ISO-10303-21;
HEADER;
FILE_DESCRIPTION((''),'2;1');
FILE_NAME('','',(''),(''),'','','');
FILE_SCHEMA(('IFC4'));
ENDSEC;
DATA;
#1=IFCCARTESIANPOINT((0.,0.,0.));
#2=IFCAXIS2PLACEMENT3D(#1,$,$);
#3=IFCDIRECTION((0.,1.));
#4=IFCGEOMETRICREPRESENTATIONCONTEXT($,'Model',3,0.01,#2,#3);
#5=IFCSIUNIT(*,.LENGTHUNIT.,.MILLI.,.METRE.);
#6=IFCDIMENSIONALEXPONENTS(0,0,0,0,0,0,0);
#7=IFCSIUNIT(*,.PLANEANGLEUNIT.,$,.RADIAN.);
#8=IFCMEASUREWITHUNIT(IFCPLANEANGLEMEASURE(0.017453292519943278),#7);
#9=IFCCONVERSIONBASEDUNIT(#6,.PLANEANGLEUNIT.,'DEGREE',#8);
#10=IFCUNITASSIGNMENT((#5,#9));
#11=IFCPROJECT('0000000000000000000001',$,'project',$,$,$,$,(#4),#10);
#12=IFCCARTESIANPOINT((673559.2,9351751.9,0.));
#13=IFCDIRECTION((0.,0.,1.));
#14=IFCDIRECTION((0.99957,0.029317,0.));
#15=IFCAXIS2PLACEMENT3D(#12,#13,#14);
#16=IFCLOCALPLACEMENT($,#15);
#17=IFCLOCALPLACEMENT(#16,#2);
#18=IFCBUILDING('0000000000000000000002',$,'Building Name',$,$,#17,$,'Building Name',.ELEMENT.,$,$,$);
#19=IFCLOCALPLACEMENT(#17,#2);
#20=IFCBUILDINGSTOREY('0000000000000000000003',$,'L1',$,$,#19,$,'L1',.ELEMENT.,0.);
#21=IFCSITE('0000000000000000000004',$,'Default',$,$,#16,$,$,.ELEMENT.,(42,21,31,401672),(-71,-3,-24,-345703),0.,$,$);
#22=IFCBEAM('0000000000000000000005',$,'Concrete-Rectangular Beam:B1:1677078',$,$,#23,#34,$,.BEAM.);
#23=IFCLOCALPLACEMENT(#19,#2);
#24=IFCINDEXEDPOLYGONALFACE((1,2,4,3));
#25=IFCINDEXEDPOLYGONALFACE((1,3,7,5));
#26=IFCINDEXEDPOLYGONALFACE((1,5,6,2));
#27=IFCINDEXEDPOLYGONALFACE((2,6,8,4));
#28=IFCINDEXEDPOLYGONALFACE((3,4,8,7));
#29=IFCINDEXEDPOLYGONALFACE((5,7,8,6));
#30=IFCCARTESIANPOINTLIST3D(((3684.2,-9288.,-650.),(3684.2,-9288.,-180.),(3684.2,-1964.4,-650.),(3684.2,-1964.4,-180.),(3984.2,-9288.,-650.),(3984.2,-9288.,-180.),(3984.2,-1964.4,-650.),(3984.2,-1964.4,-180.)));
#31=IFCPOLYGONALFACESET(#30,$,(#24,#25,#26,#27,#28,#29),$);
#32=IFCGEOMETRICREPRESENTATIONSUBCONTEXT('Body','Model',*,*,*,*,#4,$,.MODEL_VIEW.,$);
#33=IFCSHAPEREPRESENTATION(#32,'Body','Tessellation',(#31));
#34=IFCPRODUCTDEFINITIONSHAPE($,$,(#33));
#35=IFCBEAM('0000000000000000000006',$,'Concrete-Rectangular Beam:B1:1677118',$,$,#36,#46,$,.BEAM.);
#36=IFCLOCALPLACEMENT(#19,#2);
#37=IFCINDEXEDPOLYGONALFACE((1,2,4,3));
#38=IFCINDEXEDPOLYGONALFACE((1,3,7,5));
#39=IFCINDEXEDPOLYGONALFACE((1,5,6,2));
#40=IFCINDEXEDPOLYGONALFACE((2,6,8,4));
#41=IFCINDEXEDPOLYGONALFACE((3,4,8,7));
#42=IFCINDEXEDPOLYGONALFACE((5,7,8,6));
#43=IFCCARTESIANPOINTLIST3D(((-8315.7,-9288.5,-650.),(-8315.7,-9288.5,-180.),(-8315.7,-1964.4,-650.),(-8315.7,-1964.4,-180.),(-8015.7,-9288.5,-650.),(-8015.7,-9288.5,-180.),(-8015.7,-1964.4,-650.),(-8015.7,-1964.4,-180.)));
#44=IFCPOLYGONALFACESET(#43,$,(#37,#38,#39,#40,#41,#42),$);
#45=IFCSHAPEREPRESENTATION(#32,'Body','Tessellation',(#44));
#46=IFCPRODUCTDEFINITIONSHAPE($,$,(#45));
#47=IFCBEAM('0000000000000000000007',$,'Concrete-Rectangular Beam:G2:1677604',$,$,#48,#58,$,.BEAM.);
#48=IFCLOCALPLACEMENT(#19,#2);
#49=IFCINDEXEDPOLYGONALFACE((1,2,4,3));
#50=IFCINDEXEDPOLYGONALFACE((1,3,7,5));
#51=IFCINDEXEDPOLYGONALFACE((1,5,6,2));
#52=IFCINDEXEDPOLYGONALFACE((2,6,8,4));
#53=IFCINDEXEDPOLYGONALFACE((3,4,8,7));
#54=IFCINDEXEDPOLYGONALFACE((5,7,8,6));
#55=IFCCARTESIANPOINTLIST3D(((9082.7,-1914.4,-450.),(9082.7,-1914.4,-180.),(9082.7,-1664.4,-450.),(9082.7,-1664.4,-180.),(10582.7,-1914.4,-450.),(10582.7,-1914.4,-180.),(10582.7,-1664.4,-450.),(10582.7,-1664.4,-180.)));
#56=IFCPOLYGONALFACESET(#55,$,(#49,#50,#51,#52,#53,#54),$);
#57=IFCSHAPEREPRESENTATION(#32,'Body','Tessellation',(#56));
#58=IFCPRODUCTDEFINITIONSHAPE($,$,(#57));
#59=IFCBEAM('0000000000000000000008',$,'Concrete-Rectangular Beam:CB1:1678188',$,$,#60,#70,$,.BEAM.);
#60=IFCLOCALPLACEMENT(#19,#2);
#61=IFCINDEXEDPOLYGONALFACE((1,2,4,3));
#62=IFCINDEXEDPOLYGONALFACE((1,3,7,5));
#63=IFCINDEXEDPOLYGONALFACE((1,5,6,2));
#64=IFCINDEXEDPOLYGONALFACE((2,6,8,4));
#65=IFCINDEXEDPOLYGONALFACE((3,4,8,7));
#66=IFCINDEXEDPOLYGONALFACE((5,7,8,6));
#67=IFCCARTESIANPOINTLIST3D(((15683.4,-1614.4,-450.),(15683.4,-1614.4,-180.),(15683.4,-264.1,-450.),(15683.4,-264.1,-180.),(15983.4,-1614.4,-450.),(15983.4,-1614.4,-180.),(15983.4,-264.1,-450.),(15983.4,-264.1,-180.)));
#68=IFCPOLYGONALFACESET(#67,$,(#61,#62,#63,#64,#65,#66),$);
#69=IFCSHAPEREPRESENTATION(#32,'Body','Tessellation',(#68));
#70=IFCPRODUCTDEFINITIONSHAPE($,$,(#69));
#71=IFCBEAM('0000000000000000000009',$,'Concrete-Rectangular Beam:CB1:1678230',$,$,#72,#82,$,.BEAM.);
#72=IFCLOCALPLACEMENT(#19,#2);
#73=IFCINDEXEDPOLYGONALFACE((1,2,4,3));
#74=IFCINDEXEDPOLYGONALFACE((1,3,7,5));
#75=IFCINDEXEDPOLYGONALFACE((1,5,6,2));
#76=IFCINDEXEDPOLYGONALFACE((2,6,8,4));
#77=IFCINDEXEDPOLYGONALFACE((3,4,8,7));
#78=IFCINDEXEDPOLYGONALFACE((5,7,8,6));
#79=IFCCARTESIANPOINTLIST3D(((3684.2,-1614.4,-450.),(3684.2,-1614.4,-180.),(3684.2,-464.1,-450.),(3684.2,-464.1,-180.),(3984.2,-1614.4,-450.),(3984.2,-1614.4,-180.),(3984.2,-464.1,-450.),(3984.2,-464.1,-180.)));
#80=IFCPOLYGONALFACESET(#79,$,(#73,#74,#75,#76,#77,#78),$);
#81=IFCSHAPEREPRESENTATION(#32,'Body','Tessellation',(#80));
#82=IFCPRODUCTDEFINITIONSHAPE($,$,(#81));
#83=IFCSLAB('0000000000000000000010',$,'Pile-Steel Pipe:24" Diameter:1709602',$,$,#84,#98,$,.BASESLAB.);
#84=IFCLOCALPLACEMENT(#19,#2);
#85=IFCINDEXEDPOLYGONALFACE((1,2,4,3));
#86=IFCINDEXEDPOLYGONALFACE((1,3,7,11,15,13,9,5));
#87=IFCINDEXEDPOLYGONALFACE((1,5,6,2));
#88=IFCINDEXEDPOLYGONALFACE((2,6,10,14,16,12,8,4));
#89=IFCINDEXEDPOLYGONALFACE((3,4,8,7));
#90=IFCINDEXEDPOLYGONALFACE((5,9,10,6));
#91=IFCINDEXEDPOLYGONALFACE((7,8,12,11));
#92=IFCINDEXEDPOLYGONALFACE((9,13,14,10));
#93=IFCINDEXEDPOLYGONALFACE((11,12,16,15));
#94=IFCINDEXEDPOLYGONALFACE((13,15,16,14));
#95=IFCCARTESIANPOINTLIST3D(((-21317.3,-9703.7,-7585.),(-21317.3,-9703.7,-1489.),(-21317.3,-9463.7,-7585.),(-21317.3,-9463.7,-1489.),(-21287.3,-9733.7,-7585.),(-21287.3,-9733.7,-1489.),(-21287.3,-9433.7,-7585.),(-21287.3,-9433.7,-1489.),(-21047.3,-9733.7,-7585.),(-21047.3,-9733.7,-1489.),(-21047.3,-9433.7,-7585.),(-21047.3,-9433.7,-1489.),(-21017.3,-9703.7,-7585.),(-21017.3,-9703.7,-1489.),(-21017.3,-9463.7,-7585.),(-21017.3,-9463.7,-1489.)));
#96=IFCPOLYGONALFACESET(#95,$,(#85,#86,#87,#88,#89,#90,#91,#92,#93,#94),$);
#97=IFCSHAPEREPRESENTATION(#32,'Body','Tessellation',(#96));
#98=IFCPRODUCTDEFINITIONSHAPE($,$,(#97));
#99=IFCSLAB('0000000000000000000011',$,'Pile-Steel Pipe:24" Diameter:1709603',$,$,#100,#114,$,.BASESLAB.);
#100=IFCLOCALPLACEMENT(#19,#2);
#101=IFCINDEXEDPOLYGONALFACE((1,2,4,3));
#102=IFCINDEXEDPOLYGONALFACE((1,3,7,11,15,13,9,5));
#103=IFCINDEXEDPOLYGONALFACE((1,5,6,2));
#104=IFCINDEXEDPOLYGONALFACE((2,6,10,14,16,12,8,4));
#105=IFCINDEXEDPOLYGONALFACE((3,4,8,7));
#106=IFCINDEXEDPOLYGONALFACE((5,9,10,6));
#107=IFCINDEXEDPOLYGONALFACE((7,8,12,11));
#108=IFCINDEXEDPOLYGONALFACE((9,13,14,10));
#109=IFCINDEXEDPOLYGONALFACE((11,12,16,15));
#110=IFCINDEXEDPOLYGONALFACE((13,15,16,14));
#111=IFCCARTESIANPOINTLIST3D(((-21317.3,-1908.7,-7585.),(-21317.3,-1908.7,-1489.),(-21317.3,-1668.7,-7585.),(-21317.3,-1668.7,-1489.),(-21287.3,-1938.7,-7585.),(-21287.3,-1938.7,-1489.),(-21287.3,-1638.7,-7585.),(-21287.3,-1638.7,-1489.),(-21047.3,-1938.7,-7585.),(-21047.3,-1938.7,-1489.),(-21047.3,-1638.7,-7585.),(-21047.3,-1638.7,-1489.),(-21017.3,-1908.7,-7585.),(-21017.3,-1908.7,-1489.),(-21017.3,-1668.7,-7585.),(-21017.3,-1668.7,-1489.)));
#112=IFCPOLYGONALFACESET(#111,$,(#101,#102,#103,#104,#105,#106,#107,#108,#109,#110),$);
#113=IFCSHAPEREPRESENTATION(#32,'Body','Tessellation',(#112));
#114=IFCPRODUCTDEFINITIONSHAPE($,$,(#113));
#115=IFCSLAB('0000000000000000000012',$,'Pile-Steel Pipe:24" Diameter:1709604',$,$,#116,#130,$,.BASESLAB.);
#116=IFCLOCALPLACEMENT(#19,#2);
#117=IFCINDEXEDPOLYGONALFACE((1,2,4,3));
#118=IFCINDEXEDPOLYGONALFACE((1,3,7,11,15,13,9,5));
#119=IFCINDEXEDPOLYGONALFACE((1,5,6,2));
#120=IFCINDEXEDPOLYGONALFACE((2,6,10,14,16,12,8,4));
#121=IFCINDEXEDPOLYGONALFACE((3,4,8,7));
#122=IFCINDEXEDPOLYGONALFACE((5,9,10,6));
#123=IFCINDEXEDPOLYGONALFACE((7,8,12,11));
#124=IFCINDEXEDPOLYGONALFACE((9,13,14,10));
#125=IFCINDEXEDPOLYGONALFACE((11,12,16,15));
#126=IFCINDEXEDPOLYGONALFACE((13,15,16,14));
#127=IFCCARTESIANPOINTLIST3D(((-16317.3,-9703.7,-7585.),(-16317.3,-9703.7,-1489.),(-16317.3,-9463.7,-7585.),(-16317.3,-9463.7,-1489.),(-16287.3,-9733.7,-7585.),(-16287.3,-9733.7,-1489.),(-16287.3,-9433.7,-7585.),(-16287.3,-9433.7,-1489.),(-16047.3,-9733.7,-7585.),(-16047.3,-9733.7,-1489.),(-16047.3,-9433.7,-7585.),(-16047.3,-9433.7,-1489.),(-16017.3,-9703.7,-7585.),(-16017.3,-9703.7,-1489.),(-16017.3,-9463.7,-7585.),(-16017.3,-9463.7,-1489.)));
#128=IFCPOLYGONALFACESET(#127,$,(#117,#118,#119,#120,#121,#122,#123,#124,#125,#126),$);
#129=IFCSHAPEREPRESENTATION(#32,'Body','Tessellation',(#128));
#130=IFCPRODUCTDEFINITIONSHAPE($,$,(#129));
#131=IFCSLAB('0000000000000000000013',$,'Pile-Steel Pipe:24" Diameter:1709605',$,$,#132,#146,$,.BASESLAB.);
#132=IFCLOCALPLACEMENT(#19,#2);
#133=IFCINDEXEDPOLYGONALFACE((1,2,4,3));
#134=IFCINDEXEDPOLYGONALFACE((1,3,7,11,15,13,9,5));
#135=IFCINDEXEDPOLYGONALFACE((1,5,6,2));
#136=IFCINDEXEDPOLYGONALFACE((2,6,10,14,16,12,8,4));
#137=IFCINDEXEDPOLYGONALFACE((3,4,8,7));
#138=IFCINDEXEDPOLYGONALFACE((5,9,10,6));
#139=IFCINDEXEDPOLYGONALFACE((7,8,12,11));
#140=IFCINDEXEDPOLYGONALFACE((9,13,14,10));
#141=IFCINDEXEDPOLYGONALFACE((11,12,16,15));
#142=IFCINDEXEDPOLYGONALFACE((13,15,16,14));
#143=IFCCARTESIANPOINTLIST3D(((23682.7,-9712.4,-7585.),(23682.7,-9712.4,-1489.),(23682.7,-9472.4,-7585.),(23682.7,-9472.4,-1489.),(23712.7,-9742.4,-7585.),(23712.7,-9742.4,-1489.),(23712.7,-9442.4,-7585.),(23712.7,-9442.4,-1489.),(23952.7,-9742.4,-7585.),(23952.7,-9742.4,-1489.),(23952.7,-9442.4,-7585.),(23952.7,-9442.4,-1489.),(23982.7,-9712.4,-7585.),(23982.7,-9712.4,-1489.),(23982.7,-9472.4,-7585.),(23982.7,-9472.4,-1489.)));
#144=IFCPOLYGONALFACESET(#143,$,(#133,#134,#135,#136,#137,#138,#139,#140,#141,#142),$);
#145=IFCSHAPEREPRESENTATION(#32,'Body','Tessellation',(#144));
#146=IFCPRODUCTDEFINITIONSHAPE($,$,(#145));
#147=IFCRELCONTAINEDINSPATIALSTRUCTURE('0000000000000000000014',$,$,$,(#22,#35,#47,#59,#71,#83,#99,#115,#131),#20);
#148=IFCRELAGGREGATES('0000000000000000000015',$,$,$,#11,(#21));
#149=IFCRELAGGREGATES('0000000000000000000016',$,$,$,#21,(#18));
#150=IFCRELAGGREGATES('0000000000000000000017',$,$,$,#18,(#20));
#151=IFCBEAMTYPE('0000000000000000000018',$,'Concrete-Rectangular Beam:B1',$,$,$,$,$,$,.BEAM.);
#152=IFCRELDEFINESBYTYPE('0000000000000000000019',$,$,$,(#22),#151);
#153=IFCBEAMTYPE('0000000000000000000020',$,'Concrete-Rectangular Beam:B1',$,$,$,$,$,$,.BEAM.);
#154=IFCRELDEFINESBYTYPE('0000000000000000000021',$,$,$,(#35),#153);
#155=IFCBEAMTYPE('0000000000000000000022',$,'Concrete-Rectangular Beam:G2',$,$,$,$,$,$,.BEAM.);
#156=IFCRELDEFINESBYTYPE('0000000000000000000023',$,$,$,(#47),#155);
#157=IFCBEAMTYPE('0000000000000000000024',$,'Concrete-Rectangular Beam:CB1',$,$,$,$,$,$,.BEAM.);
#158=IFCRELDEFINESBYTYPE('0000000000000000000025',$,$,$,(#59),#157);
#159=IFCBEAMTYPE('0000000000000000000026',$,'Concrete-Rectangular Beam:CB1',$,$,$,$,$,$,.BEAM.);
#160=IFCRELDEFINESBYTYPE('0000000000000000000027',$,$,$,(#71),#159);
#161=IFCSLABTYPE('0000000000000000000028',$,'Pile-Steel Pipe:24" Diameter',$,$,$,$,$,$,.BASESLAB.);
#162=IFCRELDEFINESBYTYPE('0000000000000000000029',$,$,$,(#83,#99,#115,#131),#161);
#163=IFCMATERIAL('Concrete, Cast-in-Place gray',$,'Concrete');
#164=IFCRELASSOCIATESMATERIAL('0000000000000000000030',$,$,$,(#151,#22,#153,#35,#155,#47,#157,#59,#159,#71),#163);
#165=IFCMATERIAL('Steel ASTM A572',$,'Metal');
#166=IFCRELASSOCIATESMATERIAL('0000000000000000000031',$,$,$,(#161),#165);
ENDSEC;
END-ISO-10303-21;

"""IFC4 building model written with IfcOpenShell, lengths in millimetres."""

from ifc_helpers import new_model, entity, si_unit, converted_unit, direction, frame, origin, place, context, subcontext, project, spatial, indexed_curve, outline, extrude, source, transform, mapped, material, type_object, type_shapes, element, save


model = new_model("IFC4")

# Units and contexts
model_context = context("Model", 3, precision=0.01, world=origin(), true_north=direction((0.0, 1.0)))
body_context = subcontext(model_context, "Body", "Model", "MODEL_VIEW")
ifc_project = project(units=[si_unit("LENGTHUNIT", "METRE", prefix="MILLI"), converted_unit("PLANEANGLEUNIT", "DEGREE", entity("IfcPlaneAngleMeasure", 0.017453292519943278), si_unit("PLANEANGLEUNIT", "RADIAN"), dimensions=[0, 0, 0, 0, 0, 0, 0])], contexts=[model_context])

# Site, building, storey
site_placement = place(None, frame((673559.2, 9351751.9, 0.0), z_axis=(0.0, 0.0, 1.0), x_axis=(0.99957, 0.029317, 0.0)))
site = spatial("IfcSite", under=ifc_project, at=site_placement, Name="Default", CompositionType="ELEMENT", RefLatitude=(42, 21, 31, 401672), RefLongitude=(-71, -3, -24, -345703), RefElevation=0.0)
building_placement = place(site_placement, origin())
building = spatial("IfcBuilding", under=site, at=building_placement, Name="Building Name", LongName="Building Name", CompositionType="ELEMENT")
storey_placement = place(building_placement, origin())
storey = spatial("IfcBuildingStorey", under=building, at=storey_placement, Name="L1", LongName="L1", CompositionType="ELEMENT", Elevation=0.0)

# Beams
ifc_material_1 = material(Name="Concrete, Cast-in-Place gray", Category="Concrete")
beam_type_1 = type_object("IfcBeamType", Name="Concrete-Rectangular Beam:B1", PredefinedType="BEAM", material=ifc_material_1)
shared_shape_1 = source(origin(), body_context, "Body", "SweptSolid", [
    extrude(outline(indexed_curve([(-150.0, -235.0), (150.0, -235.0), (150.0, 235.0), (-150.0, 235.0), (-150.0, -235.0)], self_intersect=False)), frame((3834.2, -9288.0, -415.0), z_axis=(0.0, 1.0, 0.0), x_axis=(-1.0, 0.0, 0.0)), (0.0, 0.0, 1.0), 7323.6),
])
type_shapes(beam_type_1, [shared_shape_1])
beam_1_placement = place(storey_placement, origin())
element("IfcBeam", 1, at=beam_1_placement, inside=storey, type_object=beam_type_1, material=ifc_material_1, Name="Concrete-Rectangular Beam:B1:1677078", PredefinedType="BEAM", context=body_context, shape_type="MappedRepresentation", body=[
    mapped(shared_shape_1, transform((0.0, 0.0, 0.0), scale=1.0)),
])
beam_type_2 = type_object("IfcBeamType", Name="Concrete-Rectangular Beam:B1", PredefinedType="BEAM", material=ifc_material_1)
shared_shape_2 = source(origin(), body_context, "Body", "SweptSolid", [
    extrude(outline(indexed_curve([(-150.0, -235.0), (150.0, -235.0), (150.0, 235.0), (-150.0, 235.0), (-150.0, -235.0)], self_intersect=False)), frame((-8165.7, -9288.5, -415.0), z_axis=(0.0, 1.0, 0.0), x_axis=(-1.0, 0.0, 0.0)), (0.0, 0.0, 1.0), 7324.1),
])
type_shapes(beam_type_2, [shared_shape_2])
beam_2_placement = place(storey_placement, origin())
element("IfcBeam", 2, at=beam_2_placement, inside=storey, type_object=beam_type_2, material=ifc_material_1, Name="Concrete-Rectangular Beam:B1:1677118", PredefinedType="BEAM", context=body_context, shape_type="MappedRepresentation", body=[
    mapped(shared_shape_2, transform((0.0, 0.0, 0.0), scale=1.0)),
])
beam_type_3 = type_object("IfcBeamType", Name="Concrete-Rectangular Beam:G2", PredefinedType="BEAM", material=ifc_material_1)
shared_shape_3 = source(origin(), body_context, "Body", "SweptSolid", [
    extrude(outline(indexed_curve([(-135.0, -125.0), (135.0, -125.0), (135.0, 125.0), (-135.0, 125.0), (-135.0, -125.0)], self_intersect=False)), frame((9082.7, -1789.4, -315.0), z_axis=(1.0, 0.0, 0.0), x_axis=(0.0, 0.0, -1.0)), (0.0, 0.0, 1.0), 1500.0),
])
type_shapes(beam_type_3, [shared_shape_3])
beam_3_placement = place(storey_placement, origin())
element("IfcBeam", 3, at=beam_3_placement, inside=storey, type_object=beam_type_3, material=ifc_material_1, Name="Concrete-Rectangular Beam:G2:1677604", PredefinedType="BEAM", context=body_context, shape_type="MappedRepresentation", body=[
    mapped(shared_shape_3, transform((0.0, 0.0, 0.0), scale=1.0)),
])
beam_type_4 = type_object("IfcBeamType", Name="Concrete-Rectangular Beam:CB1", PredefinedType="BEAM", material=ifc_material_1)
shared_shape_4 = source(origin(), body_context, "Body", "SweptSolid", [
    extrude(outline(indexed_curve([(-150.0, -135.0), (150.0, -135.0), (150.0, 135.0), (-150.0, 135.0), (-150.0, -135.0)], self_intersect=False)), frame((15833.4, -1614.4, -315.0), z_axis=(0.0, 1.0, 0.0), x_axis=(-1.0, 0.0, 0.0)), (0.0, 0.0, 1.0), 1350.4),
])
type_shapes(beam_type_4, [shared_shape_4])
beam_4_placement = place(storey_placement, origin())
element("IfcBeam", 4, at=beam_4_placement, inside=storey, type_object=beam_type_4, material=ifc_material_1, Name="Concrete-Rectangular Beam:CB1:1678188", PredefinedType="BEAM", context=body_context, shape_type="MappedRepresentation", body=[
    mapped(shared_shape_4, transform((0.0, 0.0, 0.0), scale=1.0)),
])
beam_type_5 = type_object("IfcBeamType", Name="Concrete-Rectangular Beam:CB1", PredefinedType="BEAM", material=ifc_material_1)
shared_shape_5 = source(origin(), body_context, "Body", "SweptSolid", [
    extrude(outline(indexed_curve([(-150.0, -135.0), (150.0, -135.0), (150.0, 135.0), (-150.0, 135.0), (-150.0, -135.0)], self_intersect=False)), frame((3834.2, -1614.4, -315.0), z_axis=(0.0, 1.0, 0.0), x_axis=(-1.0, 0.0, 0.0)), (0.0, 0.0, 1.0), 1150.4),
])
type_shapes(beam_type_5, [shared_shape_5])
beam_5_placement = place(storey_placement, origin())
element("IfcBeam", 5, at=beam_5_placement, inside=storey, type_object=beam_type_5, material=ifc_material_1, Name="Concrete-Rectangular Beam:CB1:1678230", PredefinedType="BEAM", context=body_context, shape_type="MappedRepresentation", body=[
    mapped(shared_shape_5, transform((0.0, 0.0, 0.0), scale=1.0)),
])

# Slabs
ifc_material_2 = material(Name="Steel ASTM A572", Category="Metal")
slab_type_1 = type_object("IfcSlabType", Name="Pile-Steel Pipe:24\" Diameter", PredefinedType="BASESLAB", material=ifc_material_2)
slab_1_placement = place(storey_placement, origin())
element("IfcSlab", 6, at=slab_1_placement, inside=storey, type_object=slab_type_1, Name="Pile-Steel Pipe:24\" Diameter:1709602", PredefinedType="BASESLAB", context=body_context, shape_type="SweptSolid", body=[
    extrude(outline(indexed_curve([(-120.0, -150.0), (120.0, -150.0), (150.0, -120.0), (150.0, 120.0), (120.0, 150.0), (-120.0, 150.0), (-150.0, 120.0), (-150.0, -120.0), (-120.0, -150.0)], self_intersect=False)), frame((-21167.3, -9583.7, -7585.0), z_axis=(0.0, 0.0, 1.0), x_axis=(-1.0, 0.0, 0.0)), (0.0, 0.0, 1.0), 6096.0),
])
slab_2_placement = place(storey_placement, origin())
element("IfcSlab", 7, at=slab_2_placement, inside=storey, type_object=slab_type_1, Name="Pile-Steel Pipe:24\" Diameter:1709603", PredefinedType="BASESLAB", context=body_context, shape_type="SweptSolid", body=[
    extrude(outline(indexed_curve([(-120.0, -150.0), (120.0, -150.0), (150.0, -120.0), (150.0, 120.0), (120.0, 150.0), (-120.0, 150.0), (-150.0, 120.0), (-150.0, -120.0), (-120.0, -150.0)], self_intersect=False)), frame((-21167.3, -1788.7, -7585.0), z_axis=(0.0, 0.0, 1.0), x_axis=(-1.0, 0.0, 0.0)), (0.0, 0.0, 1.0), 6096.0),
])
slab_3_placement = place(storey_placement, origin())
element("IfcSlab", 8, at=slab_3_placement, inside=storey, type_object=slab_type_1, Name="Pile-Steel Pipe:24\" Diameter:1709604", PredefinedType="BASESLAB", context=body_context, shape_type="SweptSolid", body=[
    extrude(outline(indexed_curve([(-120.0, -150.0), (120.0, -150.0), (150.0, -120.0), (150.0, 120.0), (120.0, 150.0), (-120.0, 150.0), (-150.0, 120.0), (-150.0, -120.0), (-120.0, -150.0)], self_intersect=False)), frame((-16167.3, -9583.7, -7585.0), z_axis=(0.0, 0.0, 1.0), x_axis=(-1.0, 0.0, 0.0)), (0.0, 0.0, 1.0), 6096.0),
])
slab_4_placement = place(storey_placement, origin())
element("IfcSlab", 9, at=slab_4_placement, inside=storey, type_object=slab_type_1, Name="Pile-Steel Pipe:24\" Diameter:1709605", PredefinedType="BASESLAB", context=body_context, shape_type="SweptSolid", body=[
    extrude(outline(indexed_curve([(-120.0, -150.0), (120.0, -150.0), (150.0, -120.0), (150.0, 120.0), (120.0, 150.0), (-120.0, 150.0), (-150.0, 120.0), (-150.0, -120.0), (-120.0, -150.0)], self_intersect=False)), frame((23832.7, -9592.4, -7585.0), z_axis=(0.0, 0.0, 1.0), x_axis=(-1.0, 0.0, 0.0)), (0.0, 0.0, 1.0), 6096.0),
])

save(model, "model.ifc")
